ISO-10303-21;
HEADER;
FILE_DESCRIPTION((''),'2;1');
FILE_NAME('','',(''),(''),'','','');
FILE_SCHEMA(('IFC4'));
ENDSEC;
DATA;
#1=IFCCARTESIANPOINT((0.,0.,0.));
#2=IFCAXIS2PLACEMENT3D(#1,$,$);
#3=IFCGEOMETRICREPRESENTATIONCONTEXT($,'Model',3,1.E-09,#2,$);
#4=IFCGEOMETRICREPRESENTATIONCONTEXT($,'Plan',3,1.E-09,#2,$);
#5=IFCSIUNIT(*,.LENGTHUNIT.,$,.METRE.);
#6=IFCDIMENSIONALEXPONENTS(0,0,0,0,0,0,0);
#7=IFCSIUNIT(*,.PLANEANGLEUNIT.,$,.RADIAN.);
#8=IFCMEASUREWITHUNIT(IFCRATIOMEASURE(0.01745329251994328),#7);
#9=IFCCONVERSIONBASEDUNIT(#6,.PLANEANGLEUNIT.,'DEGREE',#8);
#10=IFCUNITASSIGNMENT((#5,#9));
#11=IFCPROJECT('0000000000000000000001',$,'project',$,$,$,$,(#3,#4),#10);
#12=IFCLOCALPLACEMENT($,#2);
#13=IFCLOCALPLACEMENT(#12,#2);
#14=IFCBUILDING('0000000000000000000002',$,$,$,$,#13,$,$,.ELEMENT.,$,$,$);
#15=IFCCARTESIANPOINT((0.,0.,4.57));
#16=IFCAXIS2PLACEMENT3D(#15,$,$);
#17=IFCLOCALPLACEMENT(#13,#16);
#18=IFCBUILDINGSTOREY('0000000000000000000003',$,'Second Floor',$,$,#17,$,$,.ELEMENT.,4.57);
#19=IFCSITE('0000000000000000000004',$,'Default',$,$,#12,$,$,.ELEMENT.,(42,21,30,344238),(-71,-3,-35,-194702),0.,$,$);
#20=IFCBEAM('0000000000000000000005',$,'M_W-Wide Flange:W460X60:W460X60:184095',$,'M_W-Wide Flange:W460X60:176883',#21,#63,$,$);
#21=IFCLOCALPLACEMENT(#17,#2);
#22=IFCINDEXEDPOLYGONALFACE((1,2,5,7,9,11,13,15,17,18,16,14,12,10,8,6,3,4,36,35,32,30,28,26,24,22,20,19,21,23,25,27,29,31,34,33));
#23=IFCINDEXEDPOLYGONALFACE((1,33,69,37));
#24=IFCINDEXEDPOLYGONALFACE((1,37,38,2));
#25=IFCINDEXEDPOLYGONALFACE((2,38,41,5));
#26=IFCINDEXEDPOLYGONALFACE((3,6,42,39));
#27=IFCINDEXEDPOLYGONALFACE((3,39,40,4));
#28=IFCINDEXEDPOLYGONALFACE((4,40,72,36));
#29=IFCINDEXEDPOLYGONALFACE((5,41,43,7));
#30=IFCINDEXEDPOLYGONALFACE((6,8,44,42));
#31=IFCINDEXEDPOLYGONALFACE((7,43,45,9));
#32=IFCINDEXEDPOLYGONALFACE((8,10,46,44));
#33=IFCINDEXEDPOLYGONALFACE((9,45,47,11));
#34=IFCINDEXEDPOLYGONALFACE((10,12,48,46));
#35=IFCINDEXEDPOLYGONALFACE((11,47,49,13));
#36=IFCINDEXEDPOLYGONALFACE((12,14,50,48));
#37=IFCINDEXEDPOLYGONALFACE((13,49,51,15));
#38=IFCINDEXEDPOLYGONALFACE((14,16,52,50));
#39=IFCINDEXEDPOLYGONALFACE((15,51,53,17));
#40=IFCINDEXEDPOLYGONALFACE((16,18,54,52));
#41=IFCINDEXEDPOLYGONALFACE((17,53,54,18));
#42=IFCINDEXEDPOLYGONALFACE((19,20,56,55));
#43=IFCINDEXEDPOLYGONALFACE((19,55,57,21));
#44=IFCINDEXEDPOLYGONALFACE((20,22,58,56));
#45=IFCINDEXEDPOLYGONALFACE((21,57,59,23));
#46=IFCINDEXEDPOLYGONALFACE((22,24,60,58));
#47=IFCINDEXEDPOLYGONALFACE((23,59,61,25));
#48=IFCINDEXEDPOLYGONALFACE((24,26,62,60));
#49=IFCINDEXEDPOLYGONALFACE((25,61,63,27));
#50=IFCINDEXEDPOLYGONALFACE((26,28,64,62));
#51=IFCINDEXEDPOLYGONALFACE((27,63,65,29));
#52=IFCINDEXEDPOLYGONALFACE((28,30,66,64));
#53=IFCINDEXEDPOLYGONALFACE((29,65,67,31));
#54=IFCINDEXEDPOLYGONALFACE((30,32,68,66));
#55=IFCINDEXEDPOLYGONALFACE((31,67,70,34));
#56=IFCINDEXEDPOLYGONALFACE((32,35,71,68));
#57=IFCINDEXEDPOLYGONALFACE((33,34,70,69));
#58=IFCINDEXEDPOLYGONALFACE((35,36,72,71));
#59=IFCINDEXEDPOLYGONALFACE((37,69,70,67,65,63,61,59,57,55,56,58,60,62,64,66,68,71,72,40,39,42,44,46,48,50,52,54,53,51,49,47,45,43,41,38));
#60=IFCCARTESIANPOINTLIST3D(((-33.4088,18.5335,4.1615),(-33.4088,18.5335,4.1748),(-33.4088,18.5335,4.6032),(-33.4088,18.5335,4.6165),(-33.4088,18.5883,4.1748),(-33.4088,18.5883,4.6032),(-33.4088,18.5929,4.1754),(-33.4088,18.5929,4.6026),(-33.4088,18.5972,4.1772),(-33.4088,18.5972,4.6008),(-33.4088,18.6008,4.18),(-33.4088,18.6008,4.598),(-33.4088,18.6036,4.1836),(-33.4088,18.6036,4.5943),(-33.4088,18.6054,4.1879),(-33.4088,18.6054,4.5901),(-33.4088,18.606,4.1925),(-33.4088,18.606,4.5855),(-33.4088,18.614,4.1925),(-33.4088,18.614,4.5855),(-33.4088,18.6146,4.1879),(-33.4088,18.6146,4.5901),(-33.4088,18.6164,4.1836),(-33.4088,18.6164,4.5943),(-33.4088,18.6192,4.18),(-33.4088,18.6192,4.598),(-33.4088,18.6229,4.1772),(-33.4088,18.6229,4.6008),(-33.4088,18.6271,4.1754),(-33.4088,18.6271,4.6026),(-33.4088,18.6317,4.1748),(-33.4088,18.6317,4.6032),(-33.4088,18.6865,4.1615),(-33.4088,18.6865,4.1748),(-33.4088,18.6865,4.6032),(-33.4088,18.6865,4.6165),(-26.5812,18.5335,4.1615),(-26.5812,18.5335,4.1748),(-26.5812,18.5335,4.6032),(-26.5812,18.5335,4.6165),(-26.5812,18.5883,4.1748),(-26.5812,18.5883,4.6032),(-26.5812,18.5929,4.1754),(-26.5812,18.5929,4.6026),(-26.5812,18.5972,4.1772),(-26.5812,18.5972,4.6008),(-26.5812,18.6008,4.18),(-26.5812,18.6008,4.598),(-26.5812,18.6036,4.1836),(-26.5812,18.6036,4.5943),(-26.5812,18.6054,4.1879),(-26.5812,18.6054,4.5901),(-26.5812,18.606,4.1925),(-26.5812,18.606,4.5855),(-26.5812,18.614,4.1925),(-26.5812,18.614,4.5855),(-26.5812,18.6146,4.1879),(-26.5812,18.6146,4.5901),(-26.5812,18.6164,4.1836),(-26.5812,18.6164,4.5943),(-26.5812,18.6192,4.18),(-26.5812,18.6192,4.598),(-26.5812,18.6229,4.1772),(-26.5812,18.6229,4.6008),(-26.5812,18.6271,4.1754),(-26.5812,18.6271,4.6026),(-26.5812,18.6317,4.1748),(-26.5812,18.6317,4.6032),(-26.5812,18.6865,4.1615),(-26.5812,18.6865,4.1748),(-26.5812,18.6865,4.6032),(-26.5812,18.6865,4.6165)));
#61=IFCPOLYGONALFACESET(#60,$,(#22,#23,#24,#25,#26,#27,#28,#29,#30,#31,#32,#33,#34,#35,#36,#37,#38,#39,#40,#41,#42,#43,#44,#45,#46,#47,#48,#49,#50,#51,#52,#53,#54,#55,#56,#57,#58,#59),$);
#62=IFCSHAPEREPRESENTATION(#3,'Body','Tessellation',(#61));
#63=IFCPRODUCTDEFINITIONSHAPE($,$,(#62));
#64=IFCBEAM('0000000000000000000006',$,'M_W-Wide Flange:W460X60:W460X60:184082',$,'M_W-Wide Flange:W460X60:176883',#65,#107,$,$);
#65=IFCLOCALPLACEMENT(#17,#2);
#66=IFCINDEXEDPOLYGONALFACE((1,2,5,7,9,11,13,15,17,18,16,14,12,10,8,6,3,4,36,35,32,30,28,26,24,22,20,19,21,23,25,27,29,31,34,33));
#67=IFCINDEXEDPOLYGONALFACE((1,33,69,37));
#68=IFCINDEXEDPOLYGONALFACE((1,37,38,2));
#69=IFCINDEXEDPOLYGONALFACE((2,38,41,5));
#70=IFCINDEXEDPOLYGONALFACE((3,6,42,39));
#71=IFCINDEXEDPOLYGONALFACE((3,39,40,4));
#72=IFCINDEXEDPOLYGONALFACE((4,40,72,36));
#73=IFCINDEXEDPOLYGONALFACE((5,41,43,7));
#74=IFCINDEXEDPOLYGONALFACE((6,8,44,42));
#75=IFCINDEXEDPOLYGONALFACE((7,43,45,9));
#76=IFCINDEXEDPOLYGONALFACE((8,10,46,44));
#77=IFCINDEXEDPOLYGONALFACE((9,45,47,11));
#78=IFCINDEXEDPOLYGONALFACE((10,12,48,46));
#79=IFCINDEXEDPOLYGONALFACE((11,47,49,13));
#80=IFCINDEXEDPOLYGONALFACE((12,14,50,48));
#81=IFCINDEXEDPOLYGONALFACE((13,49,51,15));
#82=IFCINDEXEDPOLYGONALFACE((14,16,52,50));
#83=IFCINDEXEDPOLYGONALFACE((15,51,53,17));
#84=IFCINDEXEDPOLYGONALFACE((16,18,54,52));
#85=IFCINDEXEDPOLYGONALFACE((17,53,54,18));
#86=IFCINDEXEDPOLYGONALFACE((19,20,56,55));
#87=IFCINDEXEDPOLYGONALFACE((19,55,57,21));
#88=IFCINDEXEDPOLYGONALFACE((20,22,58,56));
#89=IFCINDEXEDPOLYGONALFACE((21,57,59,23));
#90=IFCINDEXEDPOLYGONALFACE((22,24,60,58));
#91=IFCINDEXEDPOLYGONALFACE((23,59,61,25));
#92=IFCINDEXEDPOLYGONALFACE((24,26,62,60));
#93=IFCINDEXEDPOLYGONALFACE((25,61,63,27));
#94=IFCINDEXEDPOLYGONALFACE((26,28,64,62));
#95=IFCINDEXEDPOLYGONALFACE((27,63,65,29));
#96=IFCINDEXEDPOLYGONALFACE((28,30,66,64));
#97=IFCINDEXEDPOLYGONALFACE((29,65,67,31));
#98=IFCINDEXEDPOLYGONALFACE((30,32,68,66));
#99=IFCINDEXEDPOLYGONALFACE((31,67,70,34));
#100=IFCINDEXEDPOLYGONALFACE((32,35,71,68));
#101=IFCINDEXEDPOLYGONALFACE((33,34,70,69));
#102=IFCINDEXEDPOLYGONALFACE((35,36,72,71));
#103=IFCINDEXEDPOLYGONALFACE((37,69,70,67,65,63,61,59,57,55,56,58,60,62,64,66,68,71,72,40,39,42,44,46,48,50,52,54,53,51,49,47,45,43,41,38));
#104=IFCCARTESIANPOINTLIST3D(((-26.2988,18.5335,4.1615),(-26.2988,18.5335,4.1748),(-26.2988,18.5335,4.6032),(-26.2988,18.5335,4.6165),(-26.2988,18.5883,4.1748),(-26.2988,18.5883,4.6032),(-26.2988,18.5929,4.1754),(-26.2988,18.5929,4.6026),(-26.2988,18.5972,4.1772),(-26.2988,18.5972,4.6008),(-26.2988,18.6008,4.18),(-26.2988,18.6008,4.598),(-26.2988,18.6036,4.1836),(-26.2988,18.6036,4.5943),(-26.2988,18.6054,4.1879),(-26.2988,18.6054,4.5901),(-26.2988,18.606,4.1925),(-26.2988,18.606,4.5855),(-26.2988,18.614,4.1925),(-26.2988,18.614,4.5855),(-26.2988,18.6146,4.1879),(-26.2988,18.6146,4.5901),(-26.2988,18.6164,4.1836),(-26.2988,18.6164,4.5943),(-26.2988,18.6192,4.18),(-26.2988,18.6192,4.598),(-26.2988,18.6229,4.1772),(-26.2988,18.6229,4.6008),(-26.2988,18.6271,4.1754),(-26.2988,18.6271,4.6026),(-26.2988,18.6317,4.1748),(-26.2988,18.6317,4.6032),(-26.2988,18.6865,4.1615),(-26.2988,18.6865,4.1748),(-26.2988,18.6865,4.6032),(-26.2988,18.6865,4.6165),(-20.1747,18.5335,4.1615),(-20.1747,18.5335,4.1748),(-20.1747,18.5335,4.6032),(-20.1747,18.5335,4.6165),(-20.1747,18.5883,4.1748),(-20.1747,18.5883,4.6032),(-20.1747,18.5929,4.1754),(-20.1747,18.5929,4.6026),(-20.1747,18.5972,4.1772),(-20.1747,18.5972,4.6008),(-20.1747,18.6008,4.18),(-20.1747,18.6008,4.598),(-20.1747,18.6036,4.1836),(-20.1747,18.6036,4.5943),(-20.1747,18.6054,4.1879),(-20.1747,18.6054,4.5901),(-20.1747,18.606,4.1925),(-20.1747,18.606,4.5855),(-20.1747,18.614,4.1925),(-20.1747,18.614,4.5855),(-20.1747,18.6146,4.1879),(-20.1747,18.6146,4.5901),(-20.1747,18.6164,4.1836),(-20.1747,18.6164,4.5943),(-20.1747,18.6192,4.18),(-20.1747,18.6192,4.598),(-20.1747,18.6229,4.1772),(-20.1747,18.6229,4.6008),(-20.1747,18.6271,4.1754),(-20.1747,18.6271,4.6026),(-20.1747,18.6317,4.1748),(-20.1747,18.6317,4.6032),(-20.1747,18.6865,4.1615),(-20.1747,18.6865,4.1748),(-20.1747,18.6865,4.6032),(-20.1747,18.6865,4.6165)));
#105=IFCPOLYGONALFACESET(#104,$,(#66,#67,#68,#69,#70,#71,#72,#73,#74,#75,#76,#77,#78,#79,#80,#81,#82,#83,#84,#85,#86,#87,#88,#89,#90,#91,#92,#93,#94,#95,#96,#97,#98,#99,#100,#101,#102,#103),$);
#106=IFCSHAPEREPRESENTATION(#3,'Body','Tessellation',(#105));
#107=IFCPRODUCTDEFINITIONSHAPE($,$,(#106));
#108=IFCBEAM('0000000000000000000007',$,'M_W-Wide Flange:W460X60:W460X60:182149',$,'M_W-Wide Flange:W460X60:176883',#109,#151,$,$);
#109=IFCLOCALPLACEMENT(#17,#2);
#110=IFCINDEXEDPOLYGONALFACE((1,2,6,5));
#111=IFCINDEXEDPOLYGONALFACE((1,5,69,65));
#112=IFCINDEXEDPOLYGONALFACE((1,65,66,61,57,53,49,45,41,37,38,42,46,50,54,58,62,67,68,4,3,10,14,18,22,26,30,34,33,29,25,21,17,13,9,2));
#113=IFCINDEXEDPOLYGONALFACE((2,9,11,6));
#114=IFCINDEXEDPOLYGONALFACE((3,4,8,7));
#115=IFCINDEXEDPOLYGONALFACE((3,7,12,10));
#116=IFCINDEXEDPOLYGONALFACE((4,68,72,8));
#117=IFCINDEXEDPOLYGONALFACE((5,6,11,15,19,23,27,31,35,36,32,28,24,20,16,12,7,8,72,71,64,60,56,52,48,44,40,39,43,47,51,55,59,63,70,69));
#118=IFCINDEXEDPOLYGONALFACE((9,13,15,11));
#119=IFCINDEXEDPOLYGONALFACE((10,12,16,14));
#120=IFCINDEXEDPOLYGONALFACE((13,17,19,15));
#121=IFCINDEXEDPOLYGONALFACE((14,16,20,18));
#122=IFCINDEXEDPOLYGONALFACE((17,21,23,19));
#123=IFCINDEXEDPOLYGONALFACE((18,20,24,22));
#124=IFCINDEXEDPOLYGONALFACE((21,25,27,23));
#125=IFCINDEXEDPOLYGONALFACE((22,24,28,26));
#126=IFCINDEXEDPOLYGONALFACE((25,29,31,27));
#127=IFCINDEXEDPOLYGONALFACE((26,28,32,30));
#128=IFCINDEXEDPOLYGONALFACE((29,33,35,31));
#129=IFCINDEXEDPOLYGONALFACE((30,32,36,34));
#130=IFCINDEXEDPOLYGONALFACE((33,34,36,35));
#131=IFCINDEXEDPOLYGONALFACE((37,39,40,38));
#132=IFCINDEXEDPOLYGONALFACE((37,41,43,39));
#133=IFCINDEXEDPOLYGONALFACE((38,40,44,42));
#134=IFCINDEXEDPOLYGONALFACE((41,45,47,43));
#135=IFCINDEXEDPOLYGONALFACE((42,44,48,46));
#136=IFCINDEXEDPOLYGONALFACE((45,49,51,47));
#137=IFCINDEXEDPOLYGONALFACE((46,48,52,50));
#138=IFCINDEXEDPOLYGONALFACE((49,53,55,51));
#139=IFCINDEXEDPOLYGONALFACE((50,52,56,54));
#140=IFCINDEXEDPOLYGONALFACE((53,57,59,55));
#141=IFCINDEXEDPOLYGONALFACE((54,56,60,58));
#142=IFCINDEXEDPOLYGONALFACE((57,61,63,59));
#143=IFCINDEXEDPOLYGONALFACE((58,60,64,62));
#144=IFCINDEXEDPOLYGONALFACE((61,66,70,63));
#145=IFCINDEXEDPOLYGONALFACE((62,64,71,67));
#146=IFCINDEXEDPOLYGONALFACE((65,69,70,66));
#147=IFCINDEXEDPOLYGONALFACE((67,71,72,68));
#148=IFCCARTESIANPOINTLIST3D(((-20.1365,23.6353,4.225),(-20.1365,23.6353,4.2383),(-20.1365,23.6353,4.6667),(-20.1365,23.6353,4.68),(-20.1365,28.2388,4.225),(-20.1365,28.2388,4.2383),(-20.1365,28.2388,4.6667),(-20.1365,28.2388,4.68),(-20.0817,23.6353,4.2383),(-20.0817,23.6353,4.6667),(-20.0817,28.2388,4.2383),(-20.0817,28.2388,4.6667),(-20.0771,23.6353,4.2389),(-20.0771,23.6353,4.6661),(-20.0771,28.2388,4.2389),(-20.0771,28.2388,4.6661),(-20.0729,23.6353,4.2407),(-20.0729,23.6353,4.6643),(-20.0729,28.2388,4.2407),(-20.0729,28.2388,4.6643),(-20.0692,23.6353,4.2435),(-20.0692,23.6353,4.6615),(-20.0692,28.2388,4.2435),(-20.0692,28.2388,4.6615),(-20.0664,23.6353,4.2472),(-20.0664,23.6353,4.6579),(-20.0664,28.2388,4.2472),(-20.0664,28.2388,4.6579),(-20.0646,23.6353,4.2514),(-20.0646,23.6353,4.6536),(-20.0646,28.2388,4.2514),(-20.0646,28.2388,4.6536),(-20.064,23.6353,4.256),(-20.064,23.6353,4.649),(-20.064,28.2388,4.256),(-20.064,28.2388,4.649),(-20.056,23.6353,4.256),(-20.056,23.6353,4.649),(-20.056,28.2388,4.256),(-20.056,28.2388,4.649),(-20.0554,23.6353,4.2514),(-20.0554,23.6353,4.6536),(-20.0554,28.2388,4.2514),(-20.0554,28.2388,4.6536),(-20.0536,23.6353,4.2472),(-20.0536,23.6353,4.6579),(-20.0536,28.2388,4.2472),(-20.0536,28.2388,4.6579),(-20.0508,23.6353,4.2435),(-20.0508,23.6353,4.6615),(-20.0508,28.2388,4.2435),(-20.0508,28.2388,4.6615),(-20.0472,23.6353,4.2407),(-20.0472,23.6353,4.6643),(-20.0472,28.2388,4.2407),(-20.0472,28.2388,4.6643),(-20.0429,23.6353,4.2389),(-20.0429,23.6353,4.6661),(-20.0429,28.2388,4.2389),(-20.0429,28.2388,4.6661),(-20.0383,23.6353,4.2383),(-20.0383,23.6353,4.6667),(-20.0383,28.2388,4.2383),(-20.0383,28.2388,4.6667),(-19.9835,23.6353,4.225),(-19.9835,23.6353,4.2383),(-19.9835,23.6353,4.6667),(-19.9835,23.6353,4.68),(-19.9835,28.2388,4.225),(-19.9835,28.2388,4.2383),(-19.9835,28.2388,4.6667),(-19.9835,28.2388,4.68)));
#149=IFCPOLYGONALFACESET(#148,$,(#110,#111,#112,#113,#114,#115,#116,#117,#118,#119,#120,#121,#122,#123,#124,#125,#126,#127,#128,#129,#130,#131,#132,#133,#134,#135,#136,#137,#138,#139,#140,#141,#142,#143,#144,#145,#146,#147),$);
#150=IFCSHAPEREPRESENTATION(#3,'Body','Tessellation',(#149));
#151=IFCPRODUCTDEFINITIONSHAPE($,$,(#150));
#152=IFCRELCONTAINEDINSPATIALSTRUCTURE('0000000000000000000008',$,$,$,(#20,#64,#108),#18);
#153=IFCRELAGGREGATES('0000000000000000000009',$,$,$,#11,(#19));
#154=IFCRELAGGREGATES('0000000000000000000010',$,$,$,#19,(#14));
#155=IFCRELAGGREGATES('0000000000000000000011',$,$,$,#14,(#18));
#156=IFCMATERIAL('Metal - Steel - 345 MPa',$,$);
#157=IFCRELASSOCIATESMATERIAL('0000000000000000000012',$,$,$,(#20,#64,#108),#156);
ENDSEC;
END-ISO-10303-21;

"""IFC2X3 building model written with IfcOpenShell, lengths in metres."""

from ifc_helpers import new_model, entity, si_unit, converted_unit, frame, frame_2d, origin, place, context, project, spatial, polyline, circle_curve, parameter, trimmed, segment, composite_curve, outline, extrude, material, element, save


model = new_model("IFC2X3")

# Units and contexts
model_context = context("Model", 3, precision=1e-09, world=origin())
plan_context = context("Plan", 3, precision=1e-09, world=origin())
ifc_project = project(units=[si_unit("LENGTHUNIT", "METRE"), converted_unit("PLANEANGLEUNIT", "DEGREE", entity("IfcRatioMeasure", 0.01745329251994328), si_unit("PLANEANGLEUNIT", "RADIAN"), dimensions=[0, 0, 0, 0, 0, 0, 0])], contexts=[model_context, plan_context])

# Site, building, storey
site_placement = place(None, origin())
site = spatial("IfcSite", under=ifc_project, at=site_placement, Name="Default", CompositionType="ELEMENT", RefLatitude=(42, 21, 30, 344238), RefLongitude=(-71, -3, -35, -194702), RefElevation=0.0)
building_placement = place(site_placement, origin())
building = spatial("IfcBuilding", under=site, at=building_placement, CompositionType="ELEMENT")
storey_placement = place(building_placement, frame((0.0, 0.0, 4.57)))
storey = spatial("IfcBuildingStorey", under=building, at=storey_placement, Name="Second Floor", CompositionType="ELEMENT", Elevation=4.57)

# Shared definitions
ifc_material = material(Name="Metal - Steel - 345 MPa")

# Beams
beam_1_placement = place(storey_placement, frame((-26.4427, 18.61, 4.6165), z_axis=(0.0, 0.0, 1.0), x_axis=(0.0, 1.0, 0.0)))
element("IfcBeam", 1, at=beam_1_placement, inside=storey, material=ifc_material, Name="M_W-Wide Flange:W460X60:W460X60:184095", ObjectType="M_W-Wide Flange:W460X60:176883", context=model_context, shape_type="SweptSolid", body=[
    extrude(outline(composite_curve([segment(polyline([(0.2142, -0.0765), (0.2275, -0.0765)]), True, "CONTINUOUS"), segment(polyline([(0.2275, -0.0765), (0.2275, 0.0765)]), True, "CONTINUOUS"), segment(polyline([(0.2275, 0.0765), (0.2142, 0.0765)]), True, "CONTINUOUS"), segment(polyline([(0.2142, 0.0765), (0.2142, 0.0217)]), True, "CONTINUOUS"), segment(trimmed(circle_curve(frame_2d((0.1965, 0.0217), x_axis=(1.0, 0.0)), 0.0177), [parameter(270.0)], [parameter(360.0)], True, "PARAMETER"), False, "CONTINUOUS"), segment(polyline([(0.1965, 0.004), (-0.1965, 0.004)]), True, "CONTINUOUS"), segment(trimmed(circle_curve(frame_2d((-0.1965, 0.0217), x_axis=(0.0, -1.0)), 0.0177), [parameter(270.0)], [parameter(360.0)], True, "PARAMETER"), False, "CONTINUOUS"), segment(polyline([(-0.2142, 0.0217), (-0.2142, 0.0765)]), True, "CONTINUOUS"), segment(polyline([(-0.2142, 0.0765), (-0.2275, 0.0765)]), True, "CONTINUOUS"), segment(polyline([(-0.2275, 0.0765), (-0.2275, -0.0765)]), True, "CONTINUOUS"), segment(polyline([(-0.2275, -0.0765), (-0.2142, -0.0765)]), True, "CONTINUOUS"), segment(polyline([(-0.2142, -0.0765), (-0.2142, -0.0217)]), True, "CONTINUOUS"), segment(trimmed(circle_curve(frame_2d((-0.1965, -0.0217), x_axis=(-1.0, 0.0)), 0.0177), [parameter(270.0)], [parameter(360.0)], True, "PARAMETER"), False, "CONTINUOUS"), segment(polyline([(-0.1965, -0.004), (0.1965, -0.004)]), True, "CONTINUOUS"), segment(trimmed(circle_curve(frame_2d((0.1965, -0.0217), x_axis=(0.0, 1.0)), 0.0177), [parameter(270.0)], [parameter(0.0)], True, "PARAMETER"), False, "CONTINUOUS"), segment(polyline([(0.2142, -0.0217), (0.2142, -0.0765)]), True, "CONTINUOUS")], self_intersect=False)), frame((0.0, 6.9661, -0.2275), z_axis=(0.0, -1.0, 0.0), x_axis=(0.0, 0.0, -1.0)), (0.0, 0.0, 1.0), 6.8276),
])
beam_2_placement = place(storey_placement, frame((-20.063, 18.61, 4.6165), z_axis=(0.0, 0.0, 1.0), x_axis=(0.0, 1.0, 0.0)))
element("IfcBeam", 2, at=beam_2_placement, inside=storey, material=ifc_material, Name="M_W-Wide Flange:W460X60:W460X60:184082", ObjectType="M_W-Wide Flange:W460X60:176883", context=model_context, shape_type="SweptSolid", body=[
    extrude(outline(composite_curve([segment(polyline([(0.2142, -0.0765), (0.2275, -0.0765)]), True, "CONTINUOUS"), segment(polyline([(0.2275, -0.0765), (0.2275, 0.0765)]), True, "CONTINUOUS"), segment(polyline([(0.2275, 0.0765), (0.2142, 0.0765)]), True, "CONTINUOUS"), segment(polyline([(0.2142, 0.0765), (0.2142, 0.0217)]), True, "CONTINUOUS"), segment(trimmed(circle_curve(frame_2d((0.1965, 0.0217), x_axis=(0.0, 1.0)), 0.0177), [parameter(180.0)], [parameter(270.0)], True, "PARAMETER"), False, "CONTINUOUS"), segment(polyline([(0.1965, 0.004), (-0.1965, 0.004)]), True, "CONTINUOUS"), segment(trimmed(circle_curve(frame_2d((-0.1965, 0.0217), x_axis=(0.0, 1.0)), 0.0177), [parameter(90.0)], [parameter(180.0)], True, "PARAMETER"), False, "CONTINUOUS"), segment(polyline([(-0.2142, 0.0217), (-0.2142, 0.0765)]), True, "CONTINUOUS"), segment(polyline([(-0.2142, 0.0765), (-0.2275, 0.0765)]), True, "CONTINUOUS"), segment(polyline([(-0.2275, 0.0765), (-0.2275, -0.0765)]), True, "CONTINUOUS"), segment(polyline([(-0.2275, -0.0765), (-0.2142, -0.0765)]), True, "CONTINUOUS"), segment(polyline([(-0.2142, -0.0765), (-0.2142, -0.0217)]), True, "CONTINUOUS"), segment(trimmed(circle_curve(frame_2d((-0.1965, -0.0217), x_axis=(0.0, 1.0)), 0.0177), [parameter(360.0)], [parameter(90.0)], True, "PARAMETER"), False, "CONTINUOUS"), segment(polyline([(-0.1965, -0.004), (0.1965, -0.004)]), True, "CONTINUOUS"), segment(trimmed(circle_curve(frame_2d((0.1965, -0.0217), x_axis=(0.0, 1.0)), 0.0177), [parameter(270.0)], [parameter(0.0)], True, "PARAMETER"), False, "CONTINUOUS"), segment(polyline([(0.2142, -0.0217), (0.2142, -0.0765)]), True, "CONTINUOUS")], self_intersect=False)), frame((0.0, 6.2358, -0.2275), z_axis=(0.0, -1.0, 0.0), x_axis=(0.0, 0.0, -1.0)), (0.0, 0.0, 1.0), 6.1241),
])
beam_3_placement = place(storey_placement, frame((-20.06, 23.4984, 4.68)))
element("IfcBeam", 3, at=beam_3_placement, inside=storey, material=ifc_material, Name="M_W-Wide Flange:W460X60:W460X60:182149", ObjectType="M_W-Wide Flange:W460X60:176883", context=model_context, shape_type="SweptSolid", body=[
    extrude(outline(composite_curve([segment(polyline([(-0.0765, -0.2142), (-0.0765, -0.2275)]), True, "CONTINUOUS"), segment(polyline([(-0.0765, -0.2275), (0.0765, -0.2275)]), True, "CONTINUOUS"), segment(polyline([(0.0765, -0.2275), (0.0765, -0.2142)]), True, "CONTINUOUS"), segment(polyline([(0.0765, -0.2142), (0.0217, -0.2142)]), True, "CONTINUOUS"), segment(trimmed(circle_curve(frame_2d((0.0217, -0.1965), x_axis=(0.0, -1.0)), 0.0177), [parameter(270.0)], [parameter(360.0)], True, "PARAMETER"), False, "CONTINUOUS"), segment(polyline([(0.004, -0.1965), (0.004, 0.1965)]), True, "CONTINUOUS"), segment(trimmed(circle_curve(frame_2d((0.0217, 0.1965), x_axis=(-1.0, 0.0)), 0.0177), [parameter(270.0)], [parameter(360.0)], True, "PARAMETER"), False, "CONTINUOUS"), segment(polyline([(0.0217, 0.2142), (0.0765, 0.2142)]), True, "CONTINUOUS"), segment(polyline([(0.0765, 0.2142), (0.0765, 0.2275)]), True, "CONTINUOUS"), segment(polyline([(0.0765, 0.2275), (-0.0765, 0.2275)]), True, "CONTINUOUS"), segment(polyline([(-0.0765, 0.2275), (-0.0765, 0.2142)]), True, "CONTINUOUS"), segment(polyline([(-0.0765, 0.2142), (-0.0217, 0.2142)]), True, "CONTINUOUS"), segment(trimmed(circle_curve(frame_2d((-0.0217, 0.1965), x_axis=(0.0, 1.0)), 0.0177), [parameter(270.0)], [parameter(360.0)], True, "PARAMETER"), False, "CONTINUOUS"), segment(polyline([(-0.004, 0.1965), (-0.004, -0.1965)]), True, "CONTINUOUS"), segment(trimmed(circle_curve(frame_2d((-0.0217, -0.1965), x_axis=(1.0, 0.0)), 0.0177), [parameter(270.0)], [parameter(0.0)], True, "PARAMETER"), False, "CONTINUOUS"), segment(polyline([(-0.0217, -0.2142), (-0.0765, -0.2142)]), True, "CONTINUOUS")], self_intersect=False)), frame((0.0, 0.1369, -0.2275), z_axis=(0.0, -1.0, 0.0), x_axis=(1.0, 0.0, 0.0)), (0.0, 0.0, -1.0), 4.6035),
])

save(model, "model.ifc")
